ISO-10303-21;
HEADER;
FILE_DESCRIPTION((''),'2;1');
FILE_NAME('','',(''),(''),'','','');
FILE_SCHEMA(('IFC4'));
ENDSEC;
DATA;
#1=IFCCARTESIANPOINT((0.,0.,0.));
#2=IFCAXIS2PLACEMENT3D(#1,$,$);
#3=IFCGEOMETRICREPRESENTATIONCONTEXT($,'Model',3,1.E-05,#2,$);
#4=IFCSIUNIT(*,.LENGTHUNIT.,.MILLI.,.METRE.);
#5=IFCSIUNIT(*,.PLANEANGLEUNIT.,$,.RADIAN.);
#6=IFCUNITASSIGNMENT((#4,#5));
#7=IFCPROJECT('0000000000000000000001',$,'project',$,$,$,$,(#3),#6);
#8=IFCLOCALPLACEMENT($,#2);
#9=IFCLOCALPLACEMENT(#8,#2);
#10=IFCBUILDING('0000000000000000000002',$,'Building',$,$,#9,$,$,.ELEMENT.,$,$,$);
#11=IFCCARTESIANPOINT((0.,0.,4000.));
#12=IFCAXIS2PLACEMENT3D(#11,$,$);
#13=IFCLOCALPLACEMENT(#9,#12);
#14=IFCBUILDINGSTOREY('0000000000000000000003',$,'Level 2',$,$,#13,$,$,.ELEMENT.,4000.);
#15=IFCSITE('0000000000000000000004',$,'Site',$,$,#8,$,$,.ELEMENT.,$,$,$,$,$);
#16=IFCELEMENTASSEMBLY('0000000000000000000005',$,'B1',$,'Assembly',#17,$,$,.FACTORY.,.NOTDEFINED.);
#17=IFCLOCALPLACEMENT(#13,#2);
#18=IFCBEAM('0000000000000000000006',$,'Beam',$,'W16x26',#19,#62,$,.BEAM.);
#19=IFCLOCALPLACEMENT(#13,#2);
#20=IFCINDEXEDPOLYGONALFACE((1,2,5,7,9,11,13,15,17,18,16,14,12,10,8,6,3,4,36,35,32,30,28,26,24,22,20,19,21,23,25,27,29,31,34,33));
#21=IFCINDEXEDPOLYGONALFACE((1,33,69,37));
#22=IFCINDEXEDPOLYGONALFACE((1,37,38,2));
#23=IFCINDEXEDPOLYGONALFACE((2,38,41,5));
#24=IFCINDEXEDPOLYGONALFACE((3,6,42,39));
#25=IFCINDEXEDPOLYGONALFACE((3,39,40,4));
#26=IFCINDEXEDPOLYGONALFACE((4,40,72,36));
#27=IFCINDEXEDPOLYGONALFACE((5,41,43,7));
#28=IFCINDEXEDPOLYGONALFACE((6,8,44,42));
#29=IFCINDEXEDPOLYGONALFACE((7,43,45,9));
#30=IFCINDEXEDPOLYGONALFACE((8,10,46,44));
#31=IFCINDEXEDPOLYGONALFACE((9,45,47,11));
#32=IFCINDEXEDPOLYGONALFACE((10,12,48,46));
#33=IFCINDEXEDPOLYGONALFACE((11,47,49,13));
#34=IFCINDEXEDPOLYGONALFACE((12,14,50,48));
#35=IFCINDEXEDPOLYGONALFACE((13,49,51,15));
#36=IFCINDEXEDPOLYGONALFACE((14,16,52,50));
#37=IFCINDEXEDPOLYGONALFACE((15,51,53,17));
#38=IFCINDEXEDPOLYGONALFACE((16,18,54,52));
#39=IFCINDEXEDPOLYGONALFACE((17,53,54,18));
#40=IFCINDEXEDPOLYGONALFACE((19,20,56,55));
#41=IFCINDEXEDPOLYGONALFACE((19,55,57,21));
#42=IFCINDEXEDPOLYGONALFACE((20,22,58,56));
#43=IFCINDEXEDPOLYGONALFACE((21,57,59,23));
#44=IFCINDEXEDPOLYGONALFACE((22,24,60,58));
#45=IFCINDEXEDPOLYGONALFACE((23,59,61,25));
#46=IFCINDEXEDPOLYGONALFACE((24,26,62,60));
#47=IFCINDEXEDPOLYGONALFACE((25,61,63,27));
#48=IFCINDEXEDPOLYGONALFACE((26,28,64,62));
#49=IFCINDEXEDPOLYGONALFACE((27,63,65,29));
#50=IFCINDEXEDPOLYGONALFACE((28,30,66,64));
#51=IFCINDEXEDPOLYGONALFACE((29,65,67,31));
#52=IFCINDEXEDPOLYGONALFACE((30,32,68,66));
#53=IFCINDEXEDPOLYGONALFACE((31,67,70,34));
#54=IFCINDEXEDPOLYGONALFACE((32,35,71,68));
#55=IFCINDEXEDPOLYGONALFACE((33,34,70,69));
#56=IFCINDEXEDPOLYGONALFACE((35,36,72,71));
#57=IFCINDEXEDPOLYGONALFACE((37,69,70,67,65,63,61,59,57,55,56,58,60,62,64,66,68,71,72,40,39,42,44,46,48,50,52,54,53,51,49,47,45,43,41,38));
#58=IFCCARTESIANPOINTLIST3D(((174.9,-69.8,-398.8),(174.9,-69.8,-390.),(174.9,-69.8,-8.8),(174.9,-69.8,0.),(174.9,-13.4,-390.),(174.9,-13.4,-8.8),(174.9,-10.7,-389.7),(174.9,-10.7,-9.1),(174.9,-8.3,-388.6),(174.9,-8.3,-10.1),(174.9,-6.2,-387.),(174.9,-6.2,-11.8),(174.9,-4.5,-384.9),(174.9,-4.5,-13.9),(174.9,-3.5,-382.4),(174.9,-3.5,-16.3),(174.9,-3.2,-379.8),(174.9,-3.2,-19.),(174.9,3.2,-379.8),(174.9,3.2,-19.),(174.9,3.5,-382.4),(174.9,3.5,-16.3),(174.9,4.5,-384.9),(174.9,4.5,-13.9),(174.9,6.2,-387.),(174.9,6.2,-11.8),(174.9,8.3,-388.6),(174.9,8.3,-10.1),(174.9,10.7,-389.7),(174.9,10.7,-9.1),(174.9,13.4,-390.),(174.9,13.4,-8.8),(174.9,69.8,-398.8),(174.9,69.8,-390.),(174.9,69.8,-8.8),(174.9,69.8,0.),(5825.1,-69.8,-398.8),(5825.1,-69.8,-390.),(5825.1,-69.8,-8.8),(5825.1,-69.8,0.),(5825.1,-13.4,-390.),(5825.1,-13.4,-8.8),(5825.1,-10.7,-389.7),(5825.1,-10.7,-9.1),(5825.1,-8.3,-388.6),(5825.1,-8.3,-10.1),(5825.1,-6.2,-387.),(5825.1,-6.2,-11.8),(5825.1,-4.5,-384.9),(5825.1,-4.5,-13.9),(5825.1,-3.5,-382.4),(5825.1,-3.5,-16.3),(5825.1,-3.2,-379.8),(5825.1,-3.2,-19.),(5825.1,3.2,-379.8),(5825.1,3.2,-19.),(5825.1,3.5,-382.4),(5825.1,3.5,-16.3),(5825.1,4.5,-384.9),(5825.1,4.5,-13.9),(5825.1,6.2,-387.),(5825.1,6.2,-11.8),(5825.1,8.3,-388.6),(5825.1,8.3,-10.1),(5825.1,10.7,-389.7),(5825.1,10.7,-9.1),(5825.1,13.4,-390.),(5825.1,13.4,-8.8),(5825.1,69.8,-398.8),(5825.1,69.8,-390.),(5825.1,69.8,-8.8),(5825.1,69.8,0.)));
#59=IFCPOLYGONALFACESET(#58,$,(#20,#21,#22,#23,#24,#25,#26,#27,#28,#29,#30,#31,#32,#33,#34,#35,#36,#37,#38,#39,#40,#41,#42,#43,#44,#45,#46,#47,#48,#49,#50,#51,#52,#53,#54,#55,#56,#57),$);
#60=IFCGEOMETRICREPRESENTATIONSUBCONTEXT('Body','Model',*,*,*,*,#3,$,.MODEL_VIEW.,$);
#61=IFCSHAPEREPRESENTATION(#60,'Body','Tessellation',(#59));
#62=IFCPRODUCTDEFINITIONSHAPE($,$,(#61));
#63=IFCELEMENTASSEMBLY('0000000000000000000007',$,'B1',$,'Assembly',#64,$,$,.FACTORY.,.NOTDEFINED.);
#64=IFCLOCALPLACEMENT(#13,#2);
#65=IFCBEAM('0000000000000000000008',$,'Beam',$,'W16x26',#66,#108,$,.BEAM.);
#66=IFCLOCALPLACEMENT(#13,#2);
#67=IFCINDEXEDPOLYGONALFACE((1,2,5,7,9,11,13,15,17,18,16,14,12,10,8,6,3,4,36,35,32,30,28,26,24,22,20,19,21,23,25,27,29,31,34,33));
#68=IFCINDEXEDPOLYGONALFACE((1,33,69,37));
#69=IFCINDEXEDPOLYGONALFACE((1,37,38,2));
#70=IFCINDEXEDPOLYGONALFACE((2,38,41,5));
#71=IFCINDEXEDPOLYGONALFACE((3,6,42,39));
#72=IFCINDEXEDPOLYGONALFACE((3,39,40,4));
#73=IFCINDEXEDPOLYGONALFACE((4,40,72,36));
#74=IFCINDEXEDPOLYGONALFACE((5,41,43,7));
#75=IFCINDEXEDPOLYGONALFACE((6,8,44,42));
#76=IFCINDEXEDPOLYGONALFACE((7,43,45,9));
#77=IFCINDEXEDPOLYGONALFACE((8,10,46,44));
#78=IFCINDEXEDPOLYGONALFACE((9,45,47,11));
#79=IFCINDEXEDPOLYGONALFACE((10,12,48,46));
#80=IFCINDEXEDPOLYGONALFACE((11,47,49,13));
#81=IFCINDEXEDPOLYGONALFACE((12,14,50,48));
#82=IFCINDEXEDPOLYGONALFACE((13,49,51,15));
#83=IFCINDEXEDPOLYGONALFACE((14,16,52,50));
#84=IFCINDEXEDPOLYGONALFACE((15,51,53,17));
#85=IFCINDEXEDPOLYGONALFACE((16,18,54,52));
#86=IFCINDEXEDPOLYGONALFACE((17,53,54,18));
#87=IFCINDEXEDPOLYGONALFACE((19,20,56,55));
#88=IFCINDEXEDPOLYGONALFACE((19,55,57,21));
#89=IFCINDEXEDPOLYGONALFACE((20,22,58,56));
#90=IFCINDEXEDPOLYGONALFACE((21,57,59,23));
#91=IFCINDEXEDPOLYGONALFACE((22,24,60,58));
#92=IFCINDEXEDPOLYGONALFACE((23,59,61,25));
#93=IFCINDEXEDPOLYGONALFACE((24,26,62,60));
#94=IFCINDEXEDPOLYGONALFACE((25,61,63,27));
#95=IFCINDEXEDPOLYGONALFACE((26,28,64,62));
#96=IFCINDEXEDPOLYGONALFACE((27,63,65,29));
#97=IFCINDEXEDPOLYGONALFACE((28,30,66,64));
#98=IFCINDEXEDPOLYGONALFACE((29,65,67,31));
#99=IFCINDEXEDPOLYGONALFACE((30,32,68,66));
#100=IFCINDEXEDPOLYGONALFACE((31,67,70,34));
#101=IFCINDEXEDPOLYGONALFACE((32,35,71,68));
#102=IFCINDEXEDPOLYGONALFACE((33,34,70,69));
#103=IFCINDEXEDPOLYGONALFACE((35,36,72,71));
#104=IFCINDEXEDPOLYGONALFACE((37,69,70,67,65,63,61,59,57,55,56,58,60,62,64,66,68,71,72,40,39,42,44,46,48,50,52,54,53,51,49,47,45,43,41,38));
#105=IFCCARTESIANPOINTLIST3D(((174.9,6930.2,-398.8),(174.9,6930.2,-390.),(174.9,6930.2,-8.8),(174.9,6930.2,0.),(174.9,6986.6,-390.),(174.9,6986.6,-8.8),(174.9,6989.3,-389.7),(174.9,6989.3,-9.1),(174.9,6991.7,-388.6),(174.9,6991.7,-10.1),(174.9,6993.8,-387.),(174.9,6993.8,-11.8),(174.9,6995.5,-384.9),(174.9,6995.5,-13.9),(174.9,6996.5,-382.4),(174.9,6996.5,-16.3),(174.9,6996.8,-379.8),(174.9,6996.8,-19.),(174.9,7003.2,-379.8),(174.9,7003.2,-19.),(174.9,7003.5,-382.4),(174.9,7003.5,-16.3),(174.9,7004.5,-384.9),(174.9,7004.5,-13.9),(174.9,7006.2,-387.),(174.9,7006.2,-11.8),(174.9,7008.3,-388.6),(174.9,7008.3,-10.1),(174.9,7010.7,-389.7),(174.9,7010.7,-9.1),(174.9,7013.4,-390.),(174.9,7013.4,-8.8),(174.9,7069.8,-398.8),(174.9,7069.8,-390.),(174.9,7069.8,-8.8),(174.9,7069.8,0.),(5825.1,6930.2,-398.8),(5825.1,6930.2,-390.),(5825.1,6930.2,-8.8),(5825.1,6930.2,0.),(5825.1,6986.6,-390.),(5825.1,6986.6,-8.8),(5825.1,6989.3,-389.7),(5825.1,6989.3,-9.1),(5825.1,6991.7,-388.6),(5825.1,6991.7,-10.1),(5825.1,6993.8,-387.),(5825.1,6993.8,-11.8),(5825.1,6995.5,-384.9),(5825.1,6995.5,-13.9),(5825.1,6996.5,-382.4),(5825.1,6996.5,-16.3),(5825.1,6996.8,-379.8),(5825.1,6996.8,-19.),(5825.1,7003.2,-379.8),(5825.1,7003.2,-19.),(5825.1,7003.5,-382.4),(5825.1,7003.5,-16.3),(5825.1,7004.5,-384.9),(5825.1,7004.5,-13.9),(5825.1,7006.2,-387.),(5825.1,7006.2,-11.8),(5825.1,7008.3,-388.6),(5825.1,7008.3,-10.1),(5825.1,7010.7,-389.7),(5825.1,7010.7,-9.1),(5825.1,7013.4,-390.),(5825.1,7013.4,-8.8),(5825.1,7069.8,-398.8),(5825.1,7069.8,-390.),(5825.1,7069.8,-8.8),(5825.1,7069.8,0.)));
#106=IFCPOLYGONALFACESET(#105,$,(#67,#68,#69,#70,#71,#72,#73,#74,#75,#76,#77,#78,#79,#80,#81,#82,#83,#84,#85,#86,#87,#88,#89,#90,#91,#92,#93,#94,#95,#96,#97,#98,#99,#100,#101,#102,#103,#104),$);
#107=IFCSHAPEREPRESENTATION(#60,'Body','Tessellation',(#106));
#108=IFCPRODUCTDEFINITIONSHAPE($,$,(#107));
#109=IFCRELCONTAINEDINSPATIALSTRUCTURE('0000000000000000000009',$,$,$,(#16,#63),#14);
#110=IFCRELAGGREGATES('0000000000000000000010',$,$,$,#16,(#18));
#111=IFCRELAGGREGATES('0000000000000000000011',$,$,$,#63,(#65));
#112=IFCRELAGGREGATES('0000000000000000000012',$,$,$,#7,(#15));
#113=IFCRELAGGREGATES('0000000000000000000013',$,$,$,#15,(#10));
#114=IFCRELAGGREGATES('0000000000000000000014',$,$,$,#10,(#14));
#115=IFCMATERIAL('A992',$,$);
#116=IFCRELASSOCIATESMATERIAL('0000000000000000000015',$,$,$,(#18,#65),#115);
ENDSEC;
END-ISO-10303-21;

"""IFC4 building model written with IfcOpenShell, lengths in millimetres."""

from ifc_helpers import new_model, si_unit, frame, frame_2d, origin, place, context, subcontext, project, spatial, i_section, extrude, material, element, aggregate, save


model = new_model("IFC4")

# Units and contexts
model_context = context("Model", 3, precision=1e-05, world=origin())
body_context = subcontext(model_context, "Body", "Model", "MODEL_VIEW")
ifc_project = project(units=[si_unit("LENGTHUNIT", "METRE", prefix="MILLI"), si_unit("PLANEANGLEUNIT", "RADIAN")], contexts=[model_context])

# Site, building, storey
site_placement = place(None, origin())
site = spatial("IfcSite", under=ifc_project, at=site_placement, Name="Site", CompositionType="ELEMENT")
building_placement = place(site_placement, origin())
building = spatial("IfcBuilding", under=site, at=building_placement, Name="Building", CompositionType="ELEMENT")
storey_placement = place(building_placement, frame((0.0, 0.0, 4000.0)))
storey = spatial("IfcBuildingStorey", under=building, at=storey_placement, Name="Level 2", CompositionType="ELEMENT", Elevation=4000.0)

# Element assemblies, beams
assembly_1_placement = place(storey_placement, origin())
assembly_1 = element("IfcElementAssembly", 1, at=assembly_1_placement, inside=storey, Name="B1", ObjectType="Assembly", AssemblyPlace="FACTORY", PredefinedType="NOTDEFINED")
ifc_material_1 = material(Name="A992")
beam_1_placement = place(storey_placement, frame((174.9, 0.0, 0.0), z_axis=(1.0, 0.0, 0.0), x_axis=(0.0, 1.0, 0.0)))
beam_1 = element("IfcBeam", 2, at=beam_1_placement, material=ifc_material_1, Name="Beam", ObjectType="W16x26", PredefinedType="BEAM", context=body_context, shape_type="SweptSolid", body=[
    extrude(i_section(OverallWidth=139.7, OverallDepth=398.8, WebThickness=6.3, FlangeThickness=8.8, FilletRadius=10.2, at=frame_2d((0.0, -199.4))), origin(), (0.0, 0.0, 1.0), 5650.1),
])
assembly_2_placement = place(storey_placement, origin())
assembly_2 = element("IfcElementAssembly", 3, at=assembly_2_placement, inside=storey, Name="B1", ObjectType="Assembly", AssemblyPlace="FACTORY", PredefinedType="NOTDEFINED")
beam_2_placement = place(storey_placement, frame((174.9, 7000.0, 0.0), z_axis=(1.0, 0.0, 0.0), x_axis=(0.0, 1.0, 0.0)))
beam_2 = element("IfcBeam", 4, at=beam_2_placement, material=ifc_material_1, Name="Beam", ObjectType="W16x26", PredefinedType="BEAM", context=body_context, shape_type="SweptSolid", body=[
    extrude(i_section(OverallWidth=139.7, OverallDepth=398.8, WebThickness=6.3, FlangeThickness=8.8, FilletRadius=10.2, at=frame_2d((0.0, -199.4))), origin(), (0.0, 0.0, 1.0), 5650.1),
])

aggregate(assembly_1, [beam_1])
aggregate(assembly_2, [beam_2])

save(model, "model.ifc")
